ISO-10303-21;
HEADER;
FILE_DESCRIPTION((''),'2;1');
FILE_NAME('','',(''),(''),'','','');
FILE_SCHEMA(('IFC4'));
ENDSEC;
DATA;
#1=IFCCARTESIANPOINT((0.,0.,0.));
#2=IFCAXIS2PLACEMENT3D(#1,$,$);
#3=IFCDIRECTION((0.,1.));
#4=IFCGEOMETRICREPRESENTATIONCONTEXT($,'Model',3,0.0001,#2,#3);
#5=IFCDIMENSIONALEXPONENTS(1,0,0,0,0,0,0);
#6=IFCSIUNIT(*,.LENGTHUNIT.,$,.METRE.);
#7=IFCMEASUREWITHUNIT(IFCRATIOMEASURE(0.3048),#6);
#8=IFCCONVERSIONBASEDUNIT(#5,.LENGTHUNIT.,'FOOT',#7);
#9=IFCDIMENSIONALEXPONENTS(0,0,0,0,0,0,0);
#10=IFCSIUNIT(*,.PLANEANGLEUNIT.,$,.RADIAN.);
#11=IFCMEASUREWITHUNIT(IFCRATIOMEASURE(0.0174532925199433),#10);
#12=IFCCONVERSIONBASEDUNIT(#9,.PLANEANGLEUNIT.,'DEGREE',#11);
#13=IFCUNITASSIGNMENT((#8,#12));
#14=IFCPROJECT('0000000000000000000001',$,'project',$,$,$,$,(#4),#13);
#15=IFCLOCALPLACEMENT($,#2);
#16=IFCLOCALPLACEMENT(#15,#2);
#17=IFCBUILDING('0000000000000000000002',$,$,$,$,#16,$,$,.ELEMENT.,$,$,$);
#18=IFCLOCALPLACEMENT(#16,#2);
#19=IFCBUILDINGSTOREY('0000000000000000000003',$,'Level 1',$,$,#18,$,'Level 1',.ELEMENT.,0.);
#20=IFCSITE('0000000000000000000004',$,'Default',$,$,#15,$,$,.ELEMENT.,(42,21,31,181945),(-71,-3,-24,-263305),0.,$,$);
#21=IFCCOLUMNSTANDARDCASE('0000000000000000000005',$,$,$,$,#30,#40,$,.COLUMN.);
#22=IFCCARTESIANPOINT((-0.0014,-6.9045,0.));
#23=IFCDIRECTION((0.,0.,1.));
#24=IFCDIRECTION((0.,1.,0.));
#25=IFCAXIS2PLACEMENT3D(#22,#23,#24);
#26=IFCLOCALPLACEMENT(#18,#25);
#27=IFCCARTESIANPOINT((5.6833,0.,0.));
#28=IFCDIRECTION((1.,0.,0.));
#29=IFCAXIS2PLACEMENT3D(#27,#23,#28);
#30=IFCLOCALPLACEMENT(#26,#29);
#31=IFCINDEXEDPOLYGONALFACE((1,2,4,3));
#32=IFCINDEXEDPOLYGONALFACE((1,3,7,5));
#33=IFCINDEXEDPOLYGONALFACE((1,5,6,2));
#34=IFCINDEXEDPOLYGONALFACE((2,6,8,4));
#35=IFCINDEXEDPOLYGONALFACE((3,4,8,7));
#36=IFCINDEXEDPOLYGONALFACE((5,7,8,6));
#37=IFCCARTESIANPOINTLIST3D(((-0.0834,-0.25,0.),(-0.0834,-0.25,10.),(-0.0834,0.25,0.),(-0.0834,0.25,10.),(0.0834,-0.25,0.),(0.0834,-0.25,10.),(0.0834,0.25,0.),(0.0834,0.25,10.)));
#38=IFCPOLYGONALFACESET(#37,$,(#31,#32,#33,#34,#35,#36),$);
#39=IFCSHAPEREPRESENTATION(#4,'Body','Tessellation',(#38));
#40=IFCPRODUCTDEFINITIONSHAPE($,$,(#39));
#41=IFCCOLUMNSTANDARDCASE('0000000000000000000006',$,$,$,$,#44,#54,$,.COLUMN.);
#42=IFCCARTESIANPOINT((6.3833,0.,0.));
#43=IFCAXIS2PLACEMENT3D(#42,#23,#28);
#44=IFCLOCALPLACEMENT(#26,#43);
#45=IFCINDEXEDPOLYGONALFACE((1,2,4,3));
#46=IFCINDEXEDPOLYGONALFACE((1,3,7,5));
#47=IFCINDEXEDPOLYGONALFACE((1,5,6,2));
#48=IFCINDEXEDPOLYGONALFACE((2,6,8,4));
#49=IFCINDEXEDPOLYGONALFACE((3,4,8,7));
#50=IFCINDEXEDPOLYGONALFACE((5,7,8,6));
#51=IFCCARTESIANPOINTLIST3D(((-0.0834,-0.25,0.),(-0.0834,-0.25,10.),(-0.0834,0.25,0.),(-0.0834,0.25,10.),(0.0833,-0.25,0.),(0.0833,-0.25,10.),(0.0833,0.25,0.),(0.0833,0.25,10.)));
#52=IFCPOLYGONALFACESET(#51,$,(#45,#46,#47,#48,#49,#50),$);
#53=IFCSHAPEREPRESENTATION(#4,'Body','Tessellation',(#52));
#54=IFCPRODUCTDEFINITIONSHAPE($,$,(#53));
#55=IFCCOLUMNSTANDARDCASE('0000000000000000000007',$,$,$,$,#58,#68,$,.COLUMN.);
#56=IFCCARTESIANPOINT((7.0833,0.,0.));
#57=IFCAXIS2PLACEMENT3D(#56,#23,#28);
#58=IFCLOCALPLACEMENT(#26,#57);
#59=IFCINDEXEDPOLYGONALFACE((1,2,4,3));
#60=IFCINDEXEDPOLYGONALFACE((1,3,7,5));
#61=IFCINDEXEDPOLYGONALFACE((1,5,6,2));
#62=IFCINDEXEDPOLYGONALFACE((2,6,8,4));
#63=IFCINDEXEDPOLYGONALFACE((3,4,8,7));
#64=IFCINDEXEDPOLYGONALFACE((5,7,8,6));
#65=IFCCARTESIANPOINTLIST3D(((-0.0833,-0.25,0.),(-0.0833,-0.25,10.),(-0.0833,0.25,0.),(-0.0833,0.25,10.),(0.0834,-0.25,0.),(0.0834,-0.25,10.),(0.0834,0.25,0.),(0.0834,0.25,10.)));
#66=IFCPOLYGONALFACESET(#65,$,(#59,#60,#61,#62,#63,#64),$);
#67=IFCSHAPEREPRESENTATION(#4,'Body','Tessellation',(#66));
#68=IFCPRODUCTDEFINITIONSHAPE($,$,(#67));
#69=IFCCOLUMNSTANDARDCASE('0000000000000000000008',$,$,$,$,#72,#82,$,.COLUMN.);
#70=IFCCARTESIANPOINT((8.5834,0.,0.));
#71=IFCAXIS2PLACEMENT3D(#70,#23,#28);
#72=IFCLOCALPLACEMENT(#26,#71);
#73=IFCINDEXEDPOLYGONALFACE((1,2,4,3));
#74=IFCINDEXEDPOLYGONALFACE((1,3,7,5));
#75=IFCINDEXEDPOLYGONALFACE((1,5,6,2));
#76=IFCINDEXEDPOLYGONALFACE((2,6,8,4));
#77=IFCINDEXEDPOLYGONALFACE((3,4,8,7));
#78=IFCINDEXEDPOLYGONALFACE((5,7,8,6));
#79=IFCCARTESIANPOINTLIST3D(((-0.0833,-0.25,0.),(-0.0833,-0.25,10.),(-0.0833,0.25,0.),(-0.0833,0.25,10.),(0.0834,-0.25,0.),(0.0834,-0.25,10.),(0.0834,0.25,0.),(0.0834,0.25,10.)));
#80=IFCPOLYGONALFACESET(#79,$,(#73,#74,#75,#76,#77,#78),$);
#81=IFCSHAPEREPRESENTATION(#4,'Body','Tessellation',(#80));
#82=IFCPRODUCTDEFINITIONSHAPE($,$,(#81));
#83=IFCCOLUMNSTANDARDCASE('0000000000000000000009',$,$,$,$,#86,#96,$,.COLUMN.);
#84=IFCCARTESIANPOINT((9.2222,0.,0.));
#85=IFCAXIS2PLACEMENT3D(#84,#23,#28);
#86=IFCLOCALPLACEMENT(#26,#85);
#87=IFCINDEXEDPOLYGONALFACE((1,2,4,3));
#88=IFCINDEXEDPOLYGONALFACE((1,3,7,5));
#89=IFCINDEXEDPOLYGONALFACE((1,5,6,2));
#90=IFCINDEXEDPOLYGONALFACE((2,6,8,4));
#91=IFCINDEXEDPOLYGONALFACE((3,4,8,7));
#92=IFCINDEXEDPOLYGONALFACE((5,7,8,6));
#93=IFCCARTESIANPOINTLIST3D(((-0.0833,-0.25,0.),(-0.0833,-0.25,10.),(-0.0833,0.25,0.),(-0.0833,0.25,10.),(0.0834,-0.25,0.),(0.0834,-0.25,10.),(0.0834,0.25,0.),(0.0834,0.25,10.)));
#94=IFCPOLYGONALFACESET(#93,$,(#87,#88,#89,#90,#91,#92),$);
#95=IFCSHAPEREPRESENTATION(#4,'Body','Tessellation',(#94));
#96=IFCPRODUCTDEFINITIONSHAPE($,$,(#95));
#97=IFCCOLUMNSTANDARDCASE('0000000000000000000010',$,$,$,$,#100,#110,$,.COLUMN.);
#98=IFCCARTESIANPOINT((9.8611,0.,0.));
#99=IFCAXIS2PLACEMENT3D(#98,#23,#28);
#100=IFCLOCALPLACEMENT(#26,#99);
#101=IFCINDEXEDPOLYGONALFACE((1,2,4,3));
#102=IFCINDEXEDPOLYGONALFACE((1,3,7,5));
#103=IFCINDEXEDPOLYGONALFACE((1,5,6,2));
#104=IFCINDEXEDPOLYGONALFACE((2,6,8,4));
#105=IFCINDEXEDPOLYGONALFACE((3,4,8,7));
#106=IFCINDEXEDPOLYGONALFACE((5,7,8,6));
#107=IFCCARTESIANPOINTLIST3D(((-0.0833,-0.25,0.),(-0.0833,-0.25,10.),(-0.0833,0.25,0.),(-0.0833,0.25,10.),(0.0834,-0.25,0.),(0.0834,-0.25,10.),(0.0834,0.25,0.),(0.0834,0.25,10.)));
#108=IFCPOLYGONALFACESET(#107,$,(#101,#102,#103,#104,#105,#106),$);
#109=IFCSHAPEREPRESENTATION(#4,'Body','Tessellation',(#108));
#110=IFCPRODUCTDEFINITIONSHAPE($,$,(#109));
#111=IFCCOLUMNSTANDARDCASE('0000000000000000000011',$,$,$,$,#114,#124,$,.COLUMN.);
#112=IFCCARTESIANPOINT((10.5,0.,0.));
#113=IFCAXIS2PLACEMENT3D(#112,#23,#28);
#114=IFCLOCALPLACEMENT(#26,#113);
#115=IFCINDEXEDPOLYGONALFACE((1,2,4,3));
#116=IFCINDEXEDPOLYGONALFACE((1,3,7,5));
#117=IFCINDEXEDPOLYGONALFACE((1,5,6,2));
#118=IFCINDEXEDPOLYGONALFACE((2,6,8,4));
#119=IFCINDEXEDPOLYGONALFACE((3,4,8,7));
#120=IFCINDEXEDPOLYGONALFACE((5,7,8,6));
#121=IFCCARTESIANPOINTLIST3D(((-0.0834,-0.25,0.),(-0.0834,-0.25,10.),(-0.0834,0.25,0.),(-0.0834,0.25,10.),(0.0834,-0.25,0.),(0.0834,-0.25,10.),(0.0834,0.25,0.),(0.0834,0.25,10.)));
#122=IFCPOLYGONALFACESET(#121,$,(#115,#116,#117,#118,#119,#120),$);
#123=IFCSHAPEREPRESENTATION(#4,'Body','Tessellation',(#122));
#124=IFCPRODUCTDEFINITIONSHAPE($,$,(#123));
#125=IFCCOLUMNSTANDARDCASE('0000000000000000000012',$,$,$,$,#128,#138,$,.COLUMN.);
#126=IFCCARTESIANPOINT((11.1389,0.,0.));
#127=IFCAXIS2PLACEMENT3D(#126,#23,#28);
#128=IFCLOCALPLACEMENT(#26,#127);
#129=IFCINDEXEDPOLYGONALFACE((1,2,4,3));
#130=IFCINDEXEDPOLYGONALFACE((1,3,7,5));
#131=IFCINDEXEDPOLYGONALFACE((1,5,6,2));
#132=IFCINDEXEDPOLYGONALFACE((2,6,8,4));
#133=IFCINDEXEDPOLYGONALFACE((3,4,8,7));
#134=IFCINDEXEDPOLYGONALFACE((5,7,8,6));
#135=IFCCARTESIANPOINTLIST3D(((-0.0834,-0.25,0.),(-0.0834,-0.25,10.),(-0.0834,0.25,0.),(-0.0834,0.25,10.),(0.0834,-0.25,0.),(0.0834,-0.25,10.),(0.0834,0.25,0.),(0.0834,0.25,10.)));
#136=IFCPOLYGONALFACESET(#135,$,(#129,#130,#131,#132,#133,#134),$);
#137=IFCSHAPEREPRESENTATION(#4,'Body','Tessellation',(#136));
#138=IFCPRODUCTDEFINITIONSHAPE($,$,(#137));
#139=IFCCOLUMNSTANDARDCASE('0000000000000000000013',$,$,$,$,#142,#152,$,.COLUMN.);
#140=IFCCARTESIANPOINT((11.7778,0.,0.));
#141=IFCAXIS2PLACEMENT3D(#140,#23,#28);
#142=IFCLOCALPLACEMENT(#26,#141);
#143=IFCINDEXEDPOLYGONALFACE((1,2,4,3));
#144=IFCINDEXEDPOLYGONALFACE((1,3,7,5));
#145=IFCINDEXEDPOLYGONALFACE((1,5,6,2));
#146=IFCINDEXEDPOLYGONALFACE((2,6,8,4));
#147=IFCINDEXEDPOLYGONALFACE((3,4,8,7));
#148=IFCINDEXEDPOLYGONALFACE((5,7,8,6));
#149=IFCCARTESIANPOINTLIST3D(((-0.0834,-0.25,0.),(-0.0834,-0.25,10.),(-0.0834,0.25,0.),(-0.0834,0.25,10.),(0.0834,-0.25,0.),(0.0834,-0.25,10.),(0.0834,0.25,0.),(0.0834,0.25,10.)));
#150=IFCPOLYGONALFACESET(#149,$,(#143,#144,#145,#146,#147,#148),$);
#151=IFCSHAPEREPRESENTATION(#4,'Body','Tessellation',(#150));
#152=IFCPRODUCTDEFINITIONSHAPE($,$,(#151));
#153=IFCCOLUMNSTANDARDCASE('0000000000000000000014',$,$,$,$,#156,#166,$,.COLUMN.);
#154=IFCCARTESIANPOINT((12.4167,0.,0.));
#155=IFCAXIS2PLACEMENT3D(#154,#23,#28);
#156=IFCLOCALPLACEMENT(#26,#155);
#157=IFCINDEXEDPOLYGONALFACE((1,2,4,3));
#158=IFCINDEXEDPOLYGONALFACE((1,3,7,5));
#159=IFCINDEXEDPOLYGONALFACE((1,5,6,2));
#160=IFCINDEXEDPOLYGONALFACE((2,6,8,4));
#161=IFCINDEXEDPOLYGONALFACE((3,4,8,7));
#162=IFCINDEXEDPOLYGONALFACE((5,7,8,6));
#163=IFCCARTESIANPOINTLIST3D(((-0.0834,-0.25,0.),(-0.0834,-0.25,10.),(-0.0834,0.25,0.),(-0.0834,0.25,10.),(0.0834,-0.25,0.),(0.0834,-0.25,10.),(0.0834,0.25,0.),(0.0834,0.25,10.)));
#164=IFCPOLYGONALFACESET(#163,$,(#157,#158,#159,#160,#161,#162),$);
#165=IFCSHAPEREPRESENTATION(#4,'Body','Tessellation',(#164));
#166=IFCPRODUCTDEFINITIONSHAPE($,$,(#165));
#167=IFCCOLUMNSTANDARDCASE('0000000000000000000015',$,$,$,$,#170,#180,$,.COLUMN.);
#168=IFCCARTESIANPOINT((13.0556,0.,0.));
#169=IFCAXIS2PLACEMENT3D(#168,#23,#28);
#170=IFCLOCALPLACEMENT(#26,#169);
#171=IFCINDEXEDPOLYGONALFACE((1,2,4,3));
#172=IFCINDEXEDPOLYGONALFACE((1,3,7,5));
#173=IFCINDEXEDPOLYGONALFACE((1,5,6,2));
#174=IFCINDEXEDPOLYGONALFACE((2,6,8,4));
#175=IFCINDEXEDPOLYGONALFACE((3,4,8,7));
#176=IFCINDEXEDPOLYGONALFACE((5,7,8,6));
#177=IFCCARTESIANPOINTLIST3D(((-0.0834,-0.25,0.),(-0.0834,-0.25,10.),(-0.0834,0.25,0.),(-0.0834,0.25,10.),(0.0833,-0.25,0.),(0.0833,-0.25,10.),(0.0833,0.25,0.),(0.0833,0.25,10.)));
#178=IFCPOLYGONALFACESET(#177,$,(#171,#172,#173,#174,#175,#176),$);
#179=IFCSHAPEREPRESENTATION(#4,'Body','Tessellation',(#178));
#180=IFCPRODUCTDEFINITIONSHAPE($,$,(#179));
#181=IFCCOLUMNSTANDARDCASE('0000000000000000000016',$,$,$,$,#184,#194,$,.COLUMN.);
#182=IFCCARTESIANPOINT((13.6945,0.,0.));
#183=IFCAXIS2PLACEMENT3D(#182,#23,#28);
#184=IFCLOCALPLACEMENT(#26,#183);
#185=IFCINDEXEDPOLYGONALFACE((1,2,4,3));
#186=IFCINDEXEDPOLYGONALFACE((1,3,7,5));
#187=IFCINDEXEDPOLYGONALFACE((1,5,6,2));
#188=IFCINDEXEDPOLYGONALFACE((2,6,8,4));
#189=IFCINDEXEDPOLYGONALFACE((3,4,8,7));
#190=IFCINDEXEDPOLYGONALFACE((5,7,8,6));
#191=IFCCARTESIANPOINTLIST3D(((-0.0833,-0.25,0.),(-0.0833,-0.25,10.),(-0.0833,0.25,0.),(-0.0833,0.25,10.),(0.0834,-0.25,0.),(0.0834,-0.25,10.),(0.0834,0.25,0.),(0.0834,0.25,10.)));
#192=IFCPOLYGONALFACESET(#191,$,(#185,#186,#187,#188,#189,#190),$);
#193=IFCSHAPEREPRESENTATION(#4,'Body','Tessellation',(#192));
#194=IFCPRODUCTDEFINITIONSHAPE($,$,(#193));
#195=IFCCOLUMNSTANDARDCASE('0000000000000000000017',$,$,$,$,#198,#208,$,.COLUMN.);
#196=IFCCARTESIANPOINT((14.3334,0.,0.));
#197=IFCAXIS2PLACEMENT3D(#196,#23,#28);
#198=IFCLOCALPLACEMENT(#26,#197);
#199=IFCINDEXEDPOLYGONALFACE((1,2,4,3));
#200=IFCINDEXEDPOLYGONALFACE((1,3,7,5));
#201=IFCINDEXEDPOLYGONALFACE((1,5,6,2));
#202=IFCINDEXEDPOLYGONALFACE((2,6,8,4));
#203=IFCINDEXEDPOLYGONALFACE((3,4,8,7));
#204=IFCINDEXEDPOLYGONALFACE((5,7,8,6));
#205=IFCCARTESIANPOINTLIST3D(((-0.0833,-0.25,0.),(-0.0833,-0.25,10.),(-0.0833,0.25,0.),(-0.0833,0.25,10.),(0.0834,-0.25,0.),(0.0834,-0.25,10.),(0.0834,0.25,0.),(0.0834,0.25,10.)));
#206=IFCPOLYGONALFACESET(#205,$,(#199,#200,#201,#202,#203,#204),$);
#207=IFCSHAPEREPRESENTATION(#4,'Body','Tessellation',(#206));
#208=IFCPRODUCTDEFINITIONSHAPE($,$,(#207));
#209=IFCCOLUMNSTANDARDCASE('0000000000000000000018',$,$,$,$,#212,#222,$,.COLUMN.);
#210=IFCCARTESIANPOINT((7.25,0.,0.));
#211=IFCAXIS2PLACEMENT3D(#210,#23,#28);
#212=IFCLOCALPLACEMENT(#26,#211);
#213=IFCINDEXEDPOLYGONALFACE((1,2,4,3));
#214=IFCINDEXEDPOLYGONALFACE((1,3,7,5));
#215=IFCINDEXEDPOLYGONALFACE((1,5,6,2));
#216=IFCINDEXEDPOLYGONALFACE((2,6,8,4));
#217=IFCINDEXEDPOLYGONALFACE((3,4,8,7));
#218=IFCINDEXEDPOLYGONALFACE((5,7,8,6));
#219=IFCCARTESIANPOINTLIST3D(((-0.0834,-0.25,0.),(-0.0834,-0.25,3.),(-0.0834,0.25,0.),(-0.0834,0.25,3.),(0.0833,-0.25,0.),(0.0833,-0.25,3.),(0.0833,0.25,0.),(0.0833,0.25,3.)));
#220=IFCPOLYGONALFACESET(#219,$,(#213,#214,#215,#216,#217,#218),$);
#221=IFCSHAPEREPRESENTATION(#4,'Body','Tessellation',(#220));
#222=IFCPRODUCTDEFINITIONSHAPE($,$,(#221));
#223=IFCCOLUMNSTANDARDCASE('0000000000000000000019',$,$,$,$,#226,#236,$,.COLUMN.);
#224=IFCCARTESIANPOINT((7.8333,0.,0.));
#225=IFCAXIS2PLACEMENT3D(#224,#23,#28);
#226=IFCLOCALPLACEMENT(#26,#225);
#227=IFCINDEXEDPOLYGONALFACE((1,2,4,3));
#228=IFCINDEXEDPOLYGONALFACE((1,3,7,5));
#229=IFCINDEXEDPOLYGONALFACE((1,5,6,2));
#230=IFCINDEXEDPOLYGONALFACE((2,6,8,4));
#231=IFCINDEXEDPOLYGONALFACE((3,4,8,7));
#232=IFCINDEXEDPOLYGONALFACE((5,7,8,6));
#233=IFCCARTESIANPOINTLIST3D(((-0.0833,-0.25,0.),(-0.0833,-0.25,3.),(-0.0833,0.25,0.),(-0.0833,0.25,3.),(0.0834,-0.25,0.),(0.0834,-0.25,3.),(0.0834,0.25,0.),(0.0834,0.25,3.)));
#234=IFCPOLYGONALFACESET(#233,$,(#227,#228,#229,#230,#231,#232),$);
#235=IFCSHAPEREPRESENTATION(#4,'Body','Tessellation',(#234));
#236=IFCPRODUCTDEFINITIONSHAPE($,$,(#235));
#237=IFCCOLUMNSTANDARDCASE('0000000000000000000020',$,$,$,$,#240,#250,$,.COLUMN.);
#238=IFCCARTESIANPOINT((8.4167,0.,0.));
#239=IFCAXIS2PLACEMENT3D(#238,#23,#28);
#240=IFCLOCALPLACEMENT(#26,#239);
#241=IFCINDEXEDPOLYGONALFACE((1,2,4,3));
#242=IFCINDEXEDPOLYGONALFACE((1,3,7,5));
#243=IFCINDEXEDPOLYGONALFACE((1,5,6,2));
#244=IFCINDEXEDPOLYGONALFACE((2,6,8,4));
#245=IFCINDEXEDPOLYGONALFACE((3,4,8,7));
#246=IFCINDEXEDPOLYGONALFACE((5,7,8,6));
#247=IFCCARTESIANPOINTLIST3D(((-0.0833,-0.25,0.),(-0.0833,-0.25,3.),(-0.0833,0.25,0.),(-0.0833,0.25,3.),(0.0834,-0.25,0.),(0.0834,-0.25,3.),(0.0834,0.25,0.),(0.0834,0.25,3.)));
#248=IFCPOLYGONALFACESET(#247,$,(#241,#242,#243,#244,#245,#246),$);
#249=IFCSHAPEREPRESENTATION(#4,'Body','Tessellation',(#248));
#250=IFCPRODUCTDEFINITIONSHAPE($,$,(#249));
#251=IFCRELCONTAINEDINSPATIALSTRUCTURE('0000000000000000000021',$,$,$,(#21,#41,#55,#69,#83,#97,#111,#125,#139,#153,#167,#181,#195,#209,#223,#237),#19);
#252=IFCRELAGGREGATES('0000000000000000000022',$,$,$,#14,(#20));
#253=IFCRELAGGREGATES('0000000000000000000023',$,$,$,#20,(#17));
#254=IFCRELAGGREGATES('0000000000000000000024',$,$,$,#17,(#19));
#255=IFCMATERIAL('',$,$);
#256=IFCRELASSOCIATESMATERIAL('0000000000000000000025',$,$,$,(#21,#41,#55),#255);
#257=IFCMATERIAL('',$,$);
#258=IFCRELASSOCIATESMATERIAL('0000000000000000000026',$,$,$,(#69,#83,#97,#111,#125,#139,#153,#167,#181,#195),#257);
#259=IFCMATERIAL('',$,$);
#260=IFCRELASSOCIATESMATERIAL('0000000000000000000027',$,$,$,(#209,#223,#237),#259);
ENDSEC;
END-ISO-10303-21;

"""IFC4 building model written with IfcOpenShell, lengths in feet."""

from ifc_helpers import new_model, entity, si_unit, converted_unit, direction, frame, origin, place, context, project, spatial, rectangle, extrude, material, element, save


model = new_model("IFC4")

# Units and contexts
model_context = context("Model", 3, precision=0.0001, world=origin(), true_north=direction((0.0, 1.0)))
ifc_project = project(units=[converted_unit("LENGTHUNIT", "FOOT", entity("IfcRatioMeasure", 0.3048), si_unit("LENGTHUNIT", "METRE"), dimensions=[1, 0, 0, 0, 0, 0, 0]), converted_unit("PLANEANGLEUNIT", "DEGREE", entity("IfcRatioMeasure", 0.0174532925199433), si_unit("PLANEANGLEUNIT", "RADIAN"), dimensions=[0, 0, 0, 0, 0, 0, 0])], contexts=[model_context])

# Site, building, storey
site_placement = place(None, origin())
site = spatial("IfcSite", under=ifc_project, at=site_placement, Name="Default", CompositionType="ELEMENT", RefLatitude=(42, 21, 31, 181945), RefLongitude=(-71, -3, -24, -263305), RefElevation=0.0)
building_placement = place(site_placement, origin())
building = spatial("IfcBuilding", under=site, at=building_placement, CompositionType="ELEMENT")
storey_placement = place(building_placement, origin())
storey = spatial("IfcBuildingStorey", under=building, at=storey_placement, Name="Level 1", LongName="Level 1", CompositionType="ELEMENT", Elevation=0.0)

# Columns
ifc_material_1 = material(Name="")
placement_1 = place(storey_placement, frame((-0.0014, -6.9045, 0.0), z_axis=(0.0, 0.0, 1.0), x_axis=(0.0, 1.0, 0.0)))
for number, where, z_axis, x_axis in (
    (1, (5.6833, 0.0, 0.0), (0.0, 0.0, 1.0), (1.0, 0.0, 0.0)),
    (2, (6.3833, 0.0, 0.0), (0.0, 0.0, 1.0), (1.0, 0.0, 0.0)),
    (3, (7.0833, 0.0, 0.0), (0.0, 0.0, 1.0), (1.0, 0.0, 0.0)),
):
    element("IfcColumnStandardCase", number, at=place(placement_1, frame(where, z_axis=z_axis, x_axis=x_axis)), inside=storey, material=ifc_material_1, PredefinedType="COLUMN", context=model_context, shape_type="SweptSolid", body=[
        extrude(rectangle(XDim=0.1667, YDim=0.5), origin(), (0.0, 0.0, 1.0), 10.0),
    ])
ifc_material_2 = material(Name="")
for number, where, z_axis, x_axis in (
    (4, (8.5834, 0.0, 0.0), (0.0, 0.0, 1.0), (1.0, 0.0, 0.0)),
    (5, (9.2222, 0.0, 0.0), (0.0, 0.0, 1.0), (1.0, 0.0, 0.0)),
    (6, (9.8611, 0.0, 0.0), (0.0, 0.0, 1.0), (1.0, 0.0, 0.0)),
    (7, (10.5, 0.0, 0.0), (0.0, 0.0, 1.0), (1.0, 0.0, 0.0)),
    (8, (11.1389, 0.0, 0.0), (0.0, 0.0, 1.0), (1.0, 0.0, 0.0)),
    (9, (11.7778, 0.0, 0.0), (0.0, 0.0, 1.0), (1.0, 0.0, 0.0)),
    (10, (12.4167, 0.0, 0.0), (0.0, 0.0, 1.0), (1.0, 0.0, 0.0)),
    (11, (13.0556, 0.0, 0.0), (0.0, 0.0, 1.0), (1.0, 0.0, 0.0)),
    (12, (13.6945, 0.0, 0.0), (0.0, 0.0, 1.0), (1.0, 0.0, 0.0)),
    (13, (14.3334, 0.0, 0.0), (0.0, 0.0, 1.0), (1.0, 0.0, 0.0)),
):
    element("IfcColumnStandardCase", number, at=place(placement_1, frame(where, z_axis=z_axis, x_axis=x_axis)), inside=storey, material=ifc_material_2, PredefinedType="COLUMN", context=model_context, shape_type="SweptSolid", body=[
        extrude(rectangle(XDim=0.1667, YDim=0.5), origin(), (0.0, 0.0, 1.0), 10.0),
    ])
ifc_material_3 = material(Name="")
for number, where, z_axis, x_axis in (
    (14, (7.25, 0.0, 0.0), (0.0, 0.0, 1.0), (1.0, 0.0, 0.0)),
    (15, (7.8333, 0.0, 0.0), (0.0, 0.0, 1.0), (1.0, 0.0, 0.0)),
    (16, (8.4167, 0.0, 0.0), (0.0, 0.0, 1.0), (1.0, 0.0, 0.0)),
):
    element("IfcColumnStandardCase", number, at=place(placement_1, frame(where, z_axis=z_axis, x_axis=x_axis)), inside=storey, material=ifc_material_3, PredefinedType="COLUMN", context=model_context, shape_type="SweptSolid", body=[
        extrude(rectangle(XDim=0.1667, YDim=0.5), origin(), (0.0, 0.0, 1.0), 3.0),
    ])

save(model, "model.ifc")
